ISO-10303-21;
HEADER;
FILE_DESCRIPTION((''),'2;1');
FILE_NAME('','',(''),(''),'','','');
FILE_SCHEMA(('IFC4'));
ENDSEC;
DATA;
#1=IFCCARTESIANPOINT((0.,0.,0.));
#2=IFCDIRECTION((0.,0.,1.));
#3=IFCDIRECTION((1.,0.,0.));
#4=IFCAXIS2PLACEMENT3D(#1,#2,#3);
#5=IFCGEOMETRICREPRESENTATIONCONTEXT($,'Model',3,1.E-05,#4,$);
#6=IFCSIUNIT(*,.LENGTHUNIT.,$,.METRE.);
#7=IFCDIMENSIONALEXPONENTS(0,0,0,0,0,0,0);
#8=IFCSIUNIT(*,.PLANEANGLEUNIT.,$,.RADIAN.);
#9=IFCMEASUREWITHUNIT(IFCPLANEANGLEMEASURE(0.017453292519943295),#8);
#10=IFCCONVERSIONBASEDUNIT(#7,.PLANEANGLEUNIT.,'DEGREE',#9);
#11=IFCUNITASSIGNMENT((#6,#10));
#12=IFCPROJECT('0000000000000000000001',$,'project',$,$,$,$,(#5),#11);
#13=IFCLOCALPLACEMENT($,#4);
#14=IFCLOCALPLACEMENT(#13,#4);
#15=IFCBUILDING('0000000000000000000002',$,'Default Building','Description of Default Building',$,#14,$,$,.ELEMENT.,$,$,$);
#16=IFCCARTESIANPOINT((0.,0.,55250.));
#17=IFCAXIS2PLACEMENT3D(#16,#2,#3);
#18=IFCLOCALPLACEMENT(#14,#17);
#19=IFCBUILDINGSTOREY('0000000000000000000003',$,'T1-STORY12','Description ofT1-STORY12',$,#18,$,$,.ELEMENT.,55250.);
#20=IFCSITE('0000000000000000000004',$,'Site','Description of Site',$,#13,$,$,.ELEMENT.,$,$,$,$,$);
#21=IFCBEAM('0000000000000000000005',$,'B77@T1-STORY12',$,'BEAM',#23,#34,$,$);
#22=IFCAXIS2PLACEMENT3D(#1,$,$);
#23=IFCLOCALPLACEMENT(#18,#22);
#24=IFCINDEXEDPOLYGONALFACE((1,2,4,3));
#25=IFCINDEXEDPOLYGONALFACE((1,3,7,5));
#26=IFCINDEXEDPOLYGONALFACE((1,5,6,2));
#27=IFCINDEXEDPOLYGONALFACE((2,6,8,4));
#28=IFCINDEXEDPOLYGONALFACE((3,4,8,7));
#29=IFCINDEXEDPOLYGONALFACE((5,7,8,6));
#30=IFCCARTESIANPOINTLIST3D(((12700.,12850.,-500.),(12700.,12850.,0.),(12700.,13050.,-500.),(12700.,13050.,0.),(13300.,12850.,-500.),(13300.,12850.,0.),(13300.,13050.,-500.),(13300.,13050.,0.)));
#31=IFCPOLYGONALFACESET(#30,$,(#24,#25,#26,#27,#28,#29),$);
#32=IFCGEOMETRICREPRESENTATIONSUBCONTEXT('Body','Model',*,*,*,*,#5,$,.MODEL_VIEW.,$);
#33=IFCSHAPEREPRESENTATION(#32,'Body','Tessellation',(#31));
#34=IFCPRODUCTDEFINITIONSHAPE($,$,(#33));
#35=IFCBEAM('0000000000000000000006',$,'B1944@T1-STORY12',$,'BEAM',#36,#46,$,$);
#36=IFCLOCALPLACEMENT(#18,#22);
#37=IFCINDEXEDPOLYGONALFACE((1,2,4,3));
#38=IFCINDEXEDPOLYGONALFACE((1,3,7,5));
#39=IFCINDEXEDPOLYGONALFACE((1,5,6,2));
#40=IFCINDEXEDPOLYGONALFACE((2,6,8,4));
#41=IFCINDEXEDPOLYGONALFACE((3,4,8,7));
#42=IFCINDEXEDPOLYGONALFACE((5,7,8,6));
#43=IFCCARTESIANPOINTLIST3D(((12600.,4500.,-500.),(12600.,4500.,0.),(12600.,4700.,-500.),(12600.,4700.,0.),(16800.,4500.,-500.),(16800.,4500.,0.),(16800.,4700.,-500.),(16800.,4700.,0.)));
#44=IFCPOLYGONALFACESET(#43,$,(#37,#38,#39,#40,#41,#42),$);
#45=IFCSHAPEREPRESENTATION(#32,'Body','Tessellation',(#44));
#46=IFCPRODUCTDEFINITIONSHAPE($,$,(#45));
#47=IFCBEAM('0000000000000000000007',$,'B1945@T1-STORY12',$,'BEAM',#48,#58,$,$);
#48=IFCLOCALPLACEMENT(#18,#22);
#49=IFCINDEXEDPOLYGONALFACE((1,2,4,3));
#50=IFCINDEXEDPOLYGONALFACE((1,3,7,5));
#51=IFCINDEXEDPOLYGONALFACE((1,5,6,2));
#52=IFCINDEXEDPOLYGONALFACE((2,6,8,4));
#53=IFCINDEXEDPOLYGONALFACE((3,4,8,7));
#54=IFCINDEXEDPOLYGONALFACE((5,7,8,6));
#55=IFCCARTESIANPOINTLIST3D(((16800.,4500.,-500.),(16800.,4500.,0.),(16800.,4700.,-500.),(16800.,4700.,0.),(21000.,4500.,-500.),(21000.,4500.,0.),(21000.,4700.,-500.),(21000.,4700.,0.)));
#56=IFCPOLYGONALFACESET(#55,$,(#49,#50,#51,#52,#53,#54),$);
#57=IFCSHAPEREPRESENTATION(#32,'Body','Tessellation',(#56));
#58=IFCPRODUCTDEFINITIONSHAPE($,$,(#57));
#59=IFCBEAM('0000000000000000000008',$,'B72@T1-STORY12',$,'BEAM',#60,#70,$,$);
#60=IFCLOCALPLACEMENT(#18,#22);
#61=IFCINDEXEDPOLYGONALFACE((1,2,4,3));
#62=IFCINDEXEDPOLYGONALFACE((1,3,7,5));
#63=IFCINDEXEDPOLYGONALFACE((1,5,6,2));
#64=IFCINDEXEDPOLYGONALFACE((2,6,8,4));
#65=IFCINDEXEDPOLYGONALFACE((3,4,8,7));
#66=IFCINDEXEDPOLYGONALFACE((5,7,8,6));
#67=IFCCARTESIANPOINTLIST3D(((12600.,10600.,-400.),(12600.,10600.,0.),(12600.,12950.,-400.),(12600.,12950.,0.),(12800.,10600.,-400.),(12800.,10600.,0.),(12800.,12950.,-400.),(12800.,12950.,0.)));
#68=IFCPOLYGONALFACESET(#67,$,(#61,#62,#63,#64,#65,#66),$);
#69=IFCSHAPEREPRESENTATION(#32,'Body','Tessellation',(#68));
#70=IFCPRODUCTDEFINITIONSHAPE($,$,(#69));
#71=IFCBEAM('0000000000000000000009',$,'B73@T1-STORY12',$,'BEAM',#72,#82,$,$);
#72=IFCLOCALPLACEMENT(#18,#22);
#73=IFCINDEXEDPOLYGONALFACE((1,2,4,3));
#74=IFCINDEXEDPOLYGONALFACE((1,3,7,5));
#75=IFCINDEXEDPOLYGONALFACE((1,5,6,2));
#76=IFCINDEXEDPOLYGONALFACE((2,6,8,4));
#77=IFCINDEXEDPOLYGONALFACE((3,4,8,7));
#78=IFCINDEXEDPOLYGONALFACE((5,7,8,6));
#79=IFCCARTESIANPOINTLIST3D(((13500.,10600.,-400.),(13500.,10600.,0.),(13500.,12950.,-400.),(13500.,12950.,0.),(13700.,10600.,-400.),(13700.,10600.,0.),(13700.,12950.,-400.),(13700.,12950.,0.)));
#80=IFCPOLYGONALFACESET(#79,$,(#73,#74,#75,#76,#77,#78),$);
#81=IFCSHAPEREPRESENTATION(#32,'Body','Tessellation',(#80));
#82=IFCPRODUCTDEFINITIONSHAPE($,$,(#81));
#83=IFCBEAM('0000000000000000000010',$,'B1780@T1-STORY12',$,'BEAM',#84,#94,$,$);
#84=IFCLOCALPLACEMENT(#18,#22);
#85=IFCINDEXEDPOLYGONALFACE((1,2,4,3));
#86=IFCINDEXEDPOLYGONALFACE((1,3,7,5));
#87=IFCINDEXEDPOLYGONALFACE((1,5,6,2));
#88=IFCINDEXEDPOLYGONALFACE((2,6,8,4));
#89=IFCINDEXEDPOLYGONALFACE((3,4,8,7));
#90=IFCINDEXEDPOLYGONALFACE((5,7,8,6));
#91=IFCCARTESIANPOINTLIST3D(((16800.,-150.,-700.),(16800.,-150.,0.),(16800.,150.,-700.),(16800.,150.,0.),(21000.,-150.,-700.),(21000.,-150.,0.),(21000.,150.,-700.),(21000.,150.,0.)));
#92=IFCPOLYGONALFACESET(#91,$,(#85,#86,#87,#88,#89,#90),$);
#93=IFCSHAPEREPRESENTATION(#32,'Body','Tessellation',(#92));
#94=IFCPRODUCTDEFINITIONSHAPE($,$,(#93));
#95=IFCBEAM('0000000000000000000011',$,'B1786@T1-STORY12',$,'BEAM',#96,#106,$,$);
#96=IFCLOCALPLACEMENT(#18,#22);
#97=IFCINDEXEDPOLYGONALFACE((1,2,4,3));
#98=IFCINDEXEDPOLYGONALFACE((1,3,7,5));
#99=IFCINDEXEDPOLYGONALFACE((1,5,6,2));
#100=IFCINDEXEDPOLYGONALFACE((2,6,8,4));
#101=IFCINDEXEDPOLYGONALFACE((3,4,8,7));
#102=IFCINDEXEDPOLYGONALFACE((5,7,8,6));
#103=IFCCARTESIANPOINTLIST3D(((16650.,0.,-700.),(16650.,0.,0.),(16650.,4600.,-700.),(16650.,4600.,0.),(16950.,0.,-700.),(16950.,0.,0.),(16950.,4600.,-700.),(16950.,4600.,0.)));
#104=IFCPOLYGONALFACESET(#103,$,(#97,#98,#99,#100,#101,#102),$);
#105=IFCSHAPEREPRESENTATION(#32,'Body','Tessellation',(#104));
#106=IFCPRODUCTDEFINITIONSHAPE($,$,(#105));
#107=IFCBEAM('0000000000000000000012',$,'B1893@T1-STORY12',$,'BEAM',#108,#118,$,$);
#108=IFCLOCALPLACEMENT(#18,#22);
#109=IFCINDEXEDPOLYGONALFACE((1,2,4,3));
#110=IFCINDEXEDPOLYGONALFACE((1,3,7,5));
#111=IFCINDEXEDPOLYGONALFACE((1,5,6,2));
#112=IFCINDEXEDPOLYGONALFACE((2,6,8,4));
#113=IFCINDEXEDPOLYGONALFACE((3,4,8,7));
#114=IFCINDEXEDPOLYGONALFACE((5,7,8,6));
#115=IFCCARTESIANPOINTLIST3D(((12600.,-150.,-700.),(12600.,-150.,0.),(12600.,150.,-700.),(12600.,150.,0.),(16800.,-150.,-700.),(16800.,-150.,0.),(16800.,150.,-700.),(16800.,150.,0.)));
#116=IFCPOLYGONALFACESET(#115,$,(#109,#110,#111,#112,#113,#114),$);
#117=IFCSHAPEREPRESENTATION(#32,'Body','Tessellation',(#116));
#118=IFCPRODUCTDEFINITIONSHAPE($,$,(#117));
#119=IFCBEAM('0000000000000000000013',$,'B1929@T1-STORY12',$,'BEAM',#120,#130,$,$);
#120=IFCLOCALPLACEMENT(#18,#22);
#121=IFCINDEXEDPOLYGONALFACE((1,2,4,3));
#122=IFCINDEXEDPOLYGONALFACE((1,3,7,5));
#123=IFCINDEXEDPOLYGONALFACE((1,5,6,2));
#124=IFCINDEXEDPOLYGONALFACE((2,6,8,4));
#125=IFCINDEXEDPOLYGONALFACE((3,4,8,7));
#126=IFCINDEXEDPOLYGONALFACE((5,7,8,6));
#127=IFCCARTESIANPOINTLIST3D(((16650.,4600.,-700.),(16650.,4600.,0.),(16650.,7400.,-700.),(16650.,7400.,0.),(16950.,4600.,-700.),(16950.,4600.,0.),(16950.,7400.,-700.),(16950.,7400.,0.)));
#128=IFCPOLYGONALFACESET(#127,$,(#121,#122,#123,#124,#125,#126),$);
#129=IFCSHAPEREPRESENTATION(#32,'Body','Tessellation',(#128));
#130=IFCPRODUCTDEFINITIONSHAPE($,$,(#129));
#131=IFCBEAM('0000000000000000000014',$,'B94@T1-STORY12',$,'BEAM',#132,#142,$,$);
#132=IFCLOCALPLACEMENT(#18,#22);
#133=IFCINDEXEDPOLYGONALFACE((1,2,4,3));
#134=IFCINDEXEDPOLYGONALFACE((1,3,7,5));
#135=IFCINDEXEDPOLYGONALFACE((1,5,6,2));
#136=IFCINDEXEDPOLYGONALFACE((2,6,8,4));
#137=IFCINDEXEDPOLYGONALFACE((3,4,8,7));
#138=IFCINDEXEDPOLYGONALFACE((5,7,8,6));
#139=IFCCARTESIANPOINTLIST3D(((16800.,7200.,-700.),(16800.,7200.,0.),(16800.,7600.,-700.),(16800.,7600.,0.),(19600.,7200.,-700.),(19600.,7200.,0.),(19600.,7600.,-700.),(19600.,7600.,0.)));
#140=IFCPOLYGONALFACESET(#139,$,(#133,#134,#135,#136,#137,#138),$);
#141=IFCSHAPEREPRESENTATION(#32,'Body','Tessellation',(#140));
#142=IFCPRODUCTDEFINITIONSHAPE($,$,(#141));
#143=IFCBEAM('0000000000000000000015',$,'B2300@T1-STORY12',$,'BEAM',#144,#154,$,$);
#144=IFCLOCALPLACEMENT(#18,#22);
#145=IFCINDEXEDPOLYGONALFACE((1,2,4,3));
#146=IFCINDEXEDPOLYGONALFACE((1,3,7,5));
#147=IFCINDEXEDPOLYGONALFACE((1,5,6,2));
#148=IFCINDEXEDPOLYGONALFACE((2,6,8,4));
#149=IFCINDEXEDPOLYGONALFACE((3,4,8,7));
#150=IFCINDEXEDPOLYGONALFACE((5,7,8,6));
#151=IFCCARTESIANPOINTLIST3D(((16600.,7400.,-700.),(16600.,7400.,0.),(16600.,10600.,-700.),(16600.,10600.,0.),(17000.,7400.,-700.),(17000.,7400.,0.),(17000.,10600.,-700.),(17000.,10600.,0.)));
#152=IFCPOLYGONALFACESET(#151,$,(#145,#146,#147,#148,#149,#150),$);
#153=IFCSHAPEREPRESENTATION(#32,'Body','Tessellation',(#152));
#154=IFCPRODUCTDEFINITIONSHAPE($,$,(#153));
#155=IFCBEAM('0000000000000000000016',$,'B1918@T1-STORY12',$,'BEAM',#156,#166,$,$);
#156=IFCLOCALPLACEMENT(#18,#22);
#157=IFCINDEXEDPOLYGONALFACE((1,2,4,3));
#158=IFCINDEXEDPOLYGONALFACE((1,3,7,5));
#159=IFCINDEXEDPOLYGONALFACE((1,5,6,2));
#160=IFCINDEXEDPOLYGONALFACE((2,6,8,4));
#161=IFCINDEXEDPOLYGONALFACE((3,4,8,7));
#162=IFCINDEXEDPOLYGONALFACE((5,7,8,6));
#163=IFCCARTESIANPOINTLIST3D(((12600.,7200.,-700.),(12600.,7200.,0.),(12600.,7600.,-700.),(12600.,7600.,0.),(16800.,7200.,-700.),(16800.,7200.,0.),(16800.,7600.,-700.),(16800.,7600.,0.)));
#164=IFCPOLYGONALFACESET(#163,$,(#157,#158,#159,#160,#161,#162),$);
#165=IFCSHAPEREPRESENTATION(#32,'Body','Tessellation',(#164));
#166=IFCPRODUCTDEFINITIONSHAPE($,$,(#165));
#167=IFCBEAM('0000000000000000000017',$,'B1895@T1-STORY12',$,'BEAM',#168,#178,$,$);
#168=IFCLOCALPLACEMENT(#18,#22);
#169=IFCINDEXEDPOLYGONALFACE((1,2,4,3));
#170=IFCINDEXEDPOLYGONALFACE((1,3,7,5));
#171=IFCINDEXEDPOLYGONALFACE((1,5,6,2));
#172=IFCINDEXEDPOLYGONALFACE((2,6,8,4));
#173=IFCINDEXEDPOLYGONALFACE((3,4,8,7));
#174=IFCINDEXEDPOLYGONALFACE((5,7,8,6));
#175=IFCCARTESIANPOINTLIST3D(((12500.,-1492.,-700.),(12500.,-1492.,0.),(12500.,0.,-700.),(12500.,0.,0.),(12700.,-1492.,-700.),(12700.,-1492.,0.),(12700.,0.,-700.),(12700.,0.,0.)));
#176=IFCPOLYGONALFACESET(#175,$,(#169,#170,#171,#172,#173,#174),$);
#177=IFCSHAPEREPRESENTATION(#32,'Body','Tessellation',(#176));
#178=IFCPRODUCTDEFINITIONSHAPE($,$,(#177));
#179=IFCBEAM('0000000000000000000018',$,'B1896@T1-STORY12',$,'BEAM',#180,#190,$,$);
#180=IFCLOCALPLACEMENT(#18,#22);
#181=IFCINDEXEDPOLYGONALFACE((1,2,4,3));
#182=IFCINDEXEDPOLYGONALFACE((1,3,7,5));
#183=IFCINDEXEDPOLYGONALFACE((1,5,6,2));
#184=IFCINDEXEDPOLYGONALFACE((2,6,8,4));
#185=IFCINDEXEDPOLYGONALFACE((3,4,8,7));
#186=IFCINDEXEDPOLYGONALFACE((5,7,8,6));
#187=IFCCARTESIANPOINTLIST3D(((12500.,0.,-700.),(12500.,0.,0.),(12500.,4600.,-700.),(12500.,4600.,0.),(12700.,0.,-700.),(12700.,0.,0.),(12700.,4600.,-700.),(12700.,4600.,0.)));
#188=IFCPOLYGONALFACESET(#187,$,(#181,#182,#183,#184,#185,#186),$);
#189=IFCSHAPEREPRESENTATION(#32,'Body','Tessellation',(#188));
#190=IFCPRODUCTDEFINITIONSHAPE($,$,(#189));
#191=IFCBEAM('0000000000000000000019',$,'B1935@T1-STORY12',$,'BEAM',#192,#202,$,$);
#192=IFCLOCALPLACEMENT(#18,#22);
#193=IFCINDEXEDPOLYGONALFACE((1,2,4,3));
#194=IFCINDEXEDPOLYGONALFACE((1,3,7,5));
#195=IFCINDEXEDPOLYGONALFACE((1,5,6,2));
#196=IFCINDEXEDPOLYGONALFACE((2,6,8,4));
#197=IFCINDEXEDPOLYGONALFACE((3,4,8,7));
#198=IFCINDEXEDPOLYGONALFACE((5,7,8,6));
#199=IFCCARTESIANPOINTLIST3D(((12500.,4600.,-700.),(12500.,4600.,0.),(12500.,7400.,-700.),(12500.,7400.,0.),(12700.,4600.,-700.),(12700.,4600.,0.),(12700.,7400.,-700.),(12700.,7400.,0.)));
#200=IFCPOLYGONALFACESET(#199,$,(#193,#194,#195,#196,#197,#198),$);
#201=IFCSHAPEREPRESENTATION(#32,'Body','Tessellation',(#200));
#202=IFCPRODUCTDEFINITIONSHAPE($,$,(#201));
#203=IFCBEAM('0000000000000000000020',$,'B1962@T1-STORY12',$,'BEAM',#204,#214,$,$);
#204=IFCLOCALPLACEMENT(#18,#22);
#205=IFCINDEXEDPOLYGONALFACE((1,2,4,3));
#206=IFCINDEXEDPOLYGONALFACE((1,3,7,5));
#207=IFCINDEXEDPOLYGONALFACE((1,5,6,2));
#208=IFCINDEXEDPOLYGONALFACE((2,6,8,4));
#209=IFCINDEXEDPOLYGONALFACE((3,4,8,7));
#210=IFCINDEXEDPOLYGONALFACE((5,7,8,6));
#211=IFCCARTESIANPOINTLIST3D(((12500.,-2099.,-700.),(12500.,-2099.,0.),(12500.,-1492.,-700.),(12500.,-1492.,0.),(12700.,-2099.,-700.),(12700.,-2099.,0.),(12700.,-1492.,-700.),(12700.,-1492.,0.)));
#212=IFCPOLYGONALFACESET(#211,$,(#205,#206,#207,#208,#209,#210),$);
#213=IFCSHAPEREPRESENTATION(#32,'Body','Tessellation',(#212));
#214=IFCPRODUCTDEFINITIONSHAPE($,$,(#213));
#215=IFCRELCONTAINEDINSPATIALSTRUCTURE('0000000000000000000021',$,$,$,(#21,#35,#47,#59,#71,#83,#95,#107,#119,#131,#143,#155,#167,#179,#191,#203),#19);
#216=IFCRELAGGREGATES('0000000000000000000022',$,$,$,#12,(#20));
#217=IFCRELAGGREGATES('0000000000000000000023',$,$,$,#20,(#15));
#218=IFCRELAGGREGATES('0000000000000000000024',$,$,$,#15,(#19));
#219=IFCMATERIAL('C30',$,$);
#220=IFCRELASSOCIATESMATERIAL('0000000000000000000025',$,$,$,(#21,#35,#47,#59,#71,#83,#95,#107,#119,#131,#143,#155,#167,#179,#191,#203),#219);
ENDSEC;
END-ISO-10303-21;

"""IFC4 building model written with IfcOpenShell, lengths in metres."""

from ifc_helpers import new_model, entity, si_unit, converted_unit, frame, origin_with_axes, place, context, subcontext, project, spatial, rectangle, extrude, material, element, save


model = new_model("IFC4")

# Units and contexts
model_context = context("Model", 3, precision=1e-05, world=origin_with_axes())
body_context = subcontext(model_context, "Body", "Model", "MODEL_VIEW")
ifc_project = project(units=[si_unit("LENGTHUNIT", "METRE"), converted_unit("PLANEANGLEUNIT", "DEGREE", entity("IfcPlaneAngleMeasure", 0.017453292519943295), si_unit("PLANEANGLEUNIT", "RADIAN"), dimensions=[0, 0, 0, 0, 0, 0, 0])], contexts=[model_context])

# Site, building, storey
site_placement = place(None, origin_with_axes())
site = spatial("IfcSite", under=ifc_project, at=site_placement, Name="Site", Description="Description of Site", CompositionType="ELEMENT")
building_placement = place(site_placement, origin_with_axes())
building = spatial("IfcBuilding", under=site, at=building_placement, Name="Default Building", Description="Description of Default Building", CompositionType="ELEMENT")
storey_placement = place(building_placement, frame((0.0, 0.0, 55250.0), z_axis=(0.0, 0.0, 1.0), x_axis=(1.0, 0.0, 0.0)))
storey = spatial("IfcBuildingStorey", under=building, at=storey_placement, Name="T1-STORY12", Description="Description ofT1-STORY12", CompositionType="ELEMENT", Elevation=55250.0)

# Beams
ifc_material_1 = material(Name="C30")
beam_1_placement = place(storey_placement, frame((12700.0, 12950.0, -250.0), z_axis=(1.0, 0.0, 0.0), x_axis=(0.0, 1.0, 0.0)))
element("IfcBeam", 1, at=beam_1_placement, inside=storey, material=ifc_material_1, Name="B77@T1-STORY12", ObjectType="BEAM", context=body_context, shape_type="SweptSolid", body=[
    extrude(rectangle(XDim=200.0, YDim=500.0), origin_with_axes(), (0.0, 0.0, 1.0), 600.0),
])
for number, where, z_axis, x_axis, name in (
    (2, (12600.0, 4600.0, -250.0), (1.0, 0.0, 0.0), (0.0, 1.0, 0.0), "B1944@T1-STORY12"),
    (3, (16800.0, 4600.0, -250.0), (1.0, 0.0, 0.0), (0.0, 1.0, 0.0), "B1945@T1-STORY12"),
):
    element("IfcBeam", number, at=place(storey_placement, frame(where, z_axis=z_axis, x_axis=x_axis)), inside=storey, material=ifc_material_1, Name=name, ObjectType="BEAM", context=body_context, shape_type="SweptSolid", body=[
        extrude(rectangle(XDim=200.0, YDim=500.0), origin_with_axes(), (0.0, 0.0, 1.0), 4200.0),
    ])
for number, where, z_axis, x_axis, name in (
    (4, (12700.0, 10600.0, -200.0), (0.0, 1.0, 0.0), (-1.0, 0.0, 0.0), "B72@T1-STORY12"),
    (5, (13600.0, 10600.0, -200.0), (0.0, 1.0, 0.0), (-1.0, 0.0, 0.0), "B73@T1-STORY12"),
):
    element("IfcBeam", number, at=place(storey_placement, frame(where, z_axis=z_axis, x_axis=x_axis)), inside=storey, material=ifc_material_1, Name=name, ObjectType="BEAM", context=body_context, shape_type="SweptSolid", body=[
        extrude(rectangle(XDim=200.0, YDim=400.0), origin_with_axes(), (0.0, 0.0, 1.0), 2350.0),
    ])
beam_2_placement = place(storey_placement, frame((16800.0, 0.0, -350.0), z_axis=(1.0, 0.0, 0.0), x_axis=(0.0, 1.0, 0.0)))
element("IfcBeam", 6, at=beam_2_placement, inside=storey, material=ifc_material_1, Name="B1780@T1-STORY12", ObjectType="BEAM", context=body_context, shape_type="SweptSolid", body=[
    extrude(rectangle(XDim=300.0, YDim=700.0), origin_with_axes(), (0.0, 0.0, 1.0), 4200.0),
])
beam_3_placement = place(storey_placement, frame((16800.0, 0.0, -350.0), z_axis=(0.0, 1.0, 0.0), x_axis=(-1.0, 0.0, 0.0)))
element("IfcBeam", 7, at=beam_3_placement, inside=storey, material=ifc_material_1, Name="B1786@T1-STORY12", ObjectType="BEAM", context=body_context, shape_type="SweptSolid", body=[
    extrude(rectangle(XDim=300.0, YDim=700.0), origin_with_axes(), (0.0, 0.0, 1.0), 4600.0),
])
beam_4_placement = place(storey_placement, frame((12600.0, 0.0, -350.0), z_axis=(1.0, 0.0, 0.0), x_axis=(0.0, 1.0, 0.0)))
element("IfcBeam", 8, at=beam_4_placement, inside=storey, material=ifc_material_1, Name="B1893@T1-STORY12", ObjectType="BEAM", context=body_context, shape_type="SweptSolid", body=[
    extrude(rectangle(XDim=300.0, YDim=700.0), origin_with_axes(), (0.0, 0.0, 1.0), 4200.0),
])
beam_5_placement = place(storey_placement, frame((16800.0, 4600.0, -350.0), z_axis=(0.0, 1.0, 0.0), x_axis=(-1.0, 0.0, 0.0)))
element("IfcBeam", 9, at=beam_5_placement, inside=storey, material=ifc_material_1, Name="B1929@T1-STORY12", ObjectType="BEAM", context=body_context, shape_type="SweptSolid", body=[
    extrude(rectangle(XDim=300.0, YDim=700.0), origin_with_axes(), (0.0, 0.0, 1.0), 2800.0),
])
beam_6_placement = place(storey_placement, frame((16800.0, 7400.0, -350.0), z_axis=(1.0, 0.0, 0.0), x_axis=(0.0, 1.0, 0.0)))
element("IfcBeam", 10, at=beam_6_placement, inside=storey, material=ifc_material_1, Name="B94@T1-STORY12", ObjectType="BEAM", context=body_context, shape_type="SweptSolid", body=[
    extrude(rectangle(XDim=400.0, YDim=700.0), origin_with_axes(), (0.0, 0.0, 1.0), 2800.0),
])
beam_7_placement = place(storey_placement, frame((16800.0, 7400.0, -350.0), z_axis=(0.0, 1.0, 0.0), x_axis=(-1.0, 0.0, 0.0)))
element("IfcBeam", 11, at=beam_7_placement, inside=storey, material=ifc_material_1, Name="B2300@T1-STORY12", ObjectType="BEAM", context=body_context, shape_type="SweptSolid", body=[
    extrude(rectangle(XDim=400.0, YDim=700.0), origin_with_axes(), (0.0, 0.0, 1.0), 3200.0),
])
beam_8_placement = place(storey_placement, frame((12600.0, 7400.0, -350.0), z_axis=(1.0, 0.0, 0.0), x_axis=(0.0, 1.0, 0.0)))
element("IfcBeam", 12, at=beam_8_placement, inside=storey, material=ifc_material_1, Name="B1918@T1-STORY12", ObjectType="BEAM", context=body_context, shape_type="SweptSolid", body=[
    extrude(rectangle(XDim=400.0, YDim=700.0), origin_with_axes(), (0.0, 0.0, 1.0), 4200.0),
])
beam_9_placement = place(storey_placement, frame((12600.0, -1492.0, -350.0), z_axis=(0.0, 1.0, 0.0), x_axis=(-1.0, 0.0, 0.0)))
element("IfcBeam", 13, at=beam_9_placement, inside=storey, material=ifc_material_1, Name="B1895@T1-STORY12", ObjectType="BEAM", context=body_context, shape_type="SweptSolid", body=[
    extrude(rectangle(XDim=200.0, YDim=700.0), origin_with_axes(), (0.0, 0.0, 1.0), 1492.0),
])
beam_10_placement = place(storey_placement, frame((12600.0, 0.0, -350.0), z_axis=(0.0, 1.0, 0.0), x_axis=(-1.0, 0.0, 0.0)))
element("IfcBeam", 14, at=beam_10_placement, inside=storey, material=ifc_material_1, Name="B1896@T1-STORY12", ObjectType="BEAM", context=body_context, shape_type="SweptSolid", body=[
    extrude(rectangle(XDim=200.0, YDim=700.0), origin_with_axes(), (0.0, 0.0, 1.0), 4600.0),
])
beam_11_placement = place(storey_placement, frame((12600.0, 4600.0, -350.0), z_axis=(0.0, 1.0, 0.0), x_axis=(-1.0, 0.0, 0.0)))
element("IfcBeam", 15, at=beam_11_placement, inside=storey, material=ifc_material_1, Name="B1935@T1-STORY12", ObjectType="BEAM", context=body_context, shape_type="SweptSolid", body=[
    extrude(rectangle(XDim=200.0, YDim=700.0), origin_with_axes(), (0.0, 0.0, 1.0), 2800.0),
])
beam_12_placement = place(storey_placement, frame((12600.0, -2099.0, -350.0), z_axis=(0.0, 1.0, 0.0), x_axis=(-1.0, 0.0, 0.0)))
element("IfcBeam", 16, at=beam_12_placement, inside=storey, material=ifc_material_1, Name="B1962@T1-STORY12", ObjectType="BEAM", context=body_context, shape_type="SweptSolid", body=[
    extrude(rectangle(XDim=200.0, YDim=700.0), origin_with_axes(), (0.0, 0.0, 1.0), 607.0),
])

save(model, "model.ifc")
